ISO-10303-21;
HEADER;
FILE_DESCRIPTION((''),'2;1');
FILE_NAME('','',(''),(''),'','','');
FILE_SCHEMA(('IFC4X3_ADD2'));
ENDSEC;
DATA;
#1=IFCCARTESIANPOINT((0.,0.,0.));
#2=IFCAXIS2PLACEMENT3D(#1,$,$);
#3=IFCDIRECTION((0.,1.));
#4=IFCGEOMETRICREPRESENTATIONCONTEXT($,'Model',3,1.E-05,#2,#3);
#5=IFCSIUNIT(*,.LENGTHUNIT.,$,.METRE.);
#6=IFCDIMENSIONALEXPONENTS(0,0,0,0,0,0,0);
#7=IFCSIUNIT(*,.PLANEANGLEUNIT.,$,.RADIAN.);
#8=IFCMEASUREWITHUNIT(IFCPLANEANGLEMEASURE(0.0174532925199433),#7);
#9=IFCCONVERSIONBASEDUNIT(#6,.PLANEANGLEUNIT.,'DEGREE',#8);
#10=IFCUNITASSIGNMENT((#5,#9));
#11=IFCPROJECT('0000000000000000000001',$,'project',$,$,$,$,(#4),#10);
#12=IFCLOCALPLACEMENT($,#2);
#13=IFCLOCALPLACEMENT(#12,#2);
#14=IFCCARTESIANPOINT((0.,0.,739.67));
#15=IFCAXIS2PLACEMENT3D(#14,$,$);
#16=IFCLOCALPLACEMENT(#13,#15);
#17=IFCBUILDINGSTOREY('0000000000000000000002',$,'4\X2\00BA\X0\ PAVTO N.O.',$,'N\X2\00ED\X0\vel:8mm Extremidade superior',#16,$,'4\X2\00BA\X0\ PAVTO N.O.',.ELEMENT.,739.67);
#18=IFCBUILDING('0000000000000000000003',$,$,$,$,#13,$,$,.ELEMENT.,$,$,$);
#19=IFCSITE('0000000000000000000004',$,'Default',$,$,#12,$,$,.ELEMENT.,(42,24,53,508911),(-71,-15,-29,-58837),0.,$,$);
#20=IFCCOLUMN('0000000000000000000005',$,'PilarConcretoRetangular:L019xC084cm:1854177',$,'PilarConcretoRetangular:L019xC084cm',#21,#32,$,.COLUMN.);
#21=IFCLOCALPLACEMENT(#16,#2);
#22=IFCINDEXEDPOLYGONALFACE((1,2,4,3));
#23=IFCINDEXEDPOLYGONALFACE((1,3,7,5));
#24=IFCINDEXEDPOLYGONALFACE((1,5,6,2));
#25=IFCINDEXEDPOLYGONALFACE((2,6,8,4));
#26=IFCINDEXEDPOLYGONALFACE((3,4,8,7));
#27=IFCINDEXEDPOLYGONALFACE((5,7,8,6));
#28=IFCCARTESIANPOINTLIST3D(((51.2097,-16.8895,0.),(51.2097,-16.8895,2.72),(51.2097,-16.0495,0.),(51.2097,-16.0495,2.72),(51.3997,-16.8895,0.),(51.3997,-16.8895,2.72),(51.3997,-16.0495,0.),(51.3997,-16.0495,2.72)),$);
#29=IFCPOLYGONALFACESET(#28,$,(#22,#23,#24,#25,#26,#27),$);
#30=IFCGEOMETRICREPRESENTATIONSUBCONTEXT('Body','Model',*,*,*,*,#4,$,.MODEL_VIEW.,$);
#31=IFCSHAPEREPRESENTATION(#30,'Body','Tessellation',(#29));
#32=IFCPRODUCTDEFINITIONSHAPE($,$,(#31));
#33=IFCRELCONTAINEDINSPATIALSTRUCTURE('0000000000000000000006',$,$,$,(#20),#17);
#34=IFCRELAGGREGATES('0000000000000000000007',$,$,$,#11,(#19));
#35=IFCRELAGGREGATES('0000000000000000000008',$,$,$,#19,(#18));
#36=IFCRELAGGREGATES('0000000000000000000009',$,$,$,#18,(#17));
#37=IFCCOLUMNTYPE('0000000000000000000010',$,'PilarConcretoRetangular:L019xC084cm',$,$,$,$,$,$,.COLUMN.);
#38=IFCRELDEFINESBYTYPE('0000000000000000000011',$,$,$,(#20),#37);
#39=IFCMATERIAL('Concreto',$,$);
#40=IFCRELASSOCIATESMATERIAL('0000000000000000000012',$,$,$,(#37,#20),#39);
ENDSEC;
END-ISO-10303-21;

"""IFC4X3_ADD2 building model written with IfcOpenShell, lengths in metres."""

from ifc_helpers import new_model, entity, si_unit, converted_unit, direction, frame, frame_2d, origin, place, context, subcontext, project, spatial, rectangle, extrude, source, transform, mapped, material, material_profile, profile_set, profile_usage, type_object, type_shapes, element, save


model = new_model("IFC4X3_ADD2")

# Units and contexts
model_context = context("Model", 3, precision=1e-05, world=origin(), true_north=direction((0.0, 1.0)))
body_context = subcontext(model_context, "Body", "Model", "MODEL_VIEW")
ifc_project = project(units=[si_unit("LENGTHUNIT", "METRE"), converted_unit("PLANEANGLEUNIT", "DEGREE", entity("IfcPlaneAngleMeasure", 0.0174532925199433), si_unit("PLANEANGLEUNIT", "RADIAN"), dimensions=[0, 0, 0, 0, 0, 0, 0])], contexts=[model_context])

# Site, building, storey
site_placement = place(None, origin())
site = spatial("IfcSite", under=ifc_project, at=site_placement, Name="Default", CompositionType="ELEMENT", RefLatitude=(42, 24, 53, 508911), RefLongitude=(-71, -15, -29, -58837), RefElevation=0.0)
building_placement = place(site_placement, origin())
building = spatial("IfcBuilding", under=site, at=building_placement, CompositionType="ELEMENT")
storey_placement = place(building_placement, frame((0.0, 0.0, 739.67)))
storey = spatial("IfcBuildingStorey", under=building, at=storey_placement, Name="4º PAVTO N.O.", ObjectType="Nível:8mm Extremidade superior", LongName="4º PAVTO N.O.", CompositionType="ELEMENT", Elevation=739.67)

# Column
ifc_material = material(Name="Concreto")
ifc_material_profile_1 = material_profile(ifc_material, rectangle(XDim=0.19, YDim=0.84, at=frame_2d((0.0, 0.0), x_axis=(1.0, 0.0))), Name="L019xC084cm")
ifc_profile_set_1 = profile_set([ifc_material_profile_1], Name="L019xC084cm")
ifc_profile_usage_1 = profile_usage(ifc_profile_set_1)
column_type_1 = type_object("IfcColumnType", Name="PilarConcretoRetangular:L019xC084cm", PredefinedType="COLUMN", material=ifc_profile_set_1)
shared_shape_1 = source(origin(), body_context, "Body", "SweptSolid", [
    extrude(rectangle(XDim=0.19, YDim=0.84, at=frame_2d((0.0, 0.0), x_axis=(1.0, 0.0))), frame((51.3047, -16.4695, 739.67), z_axis=(0.0, 0.0, 1.0), x_axis=(-1.0, 0.0, 0.0)), (0.0, 0.0, 1.0), 2.72),
])
type_shapes(column_type_1, [shared_shape_1])
column_1_placement = place(storey_placement, frame((0.0, 0.0, -739.67)))
element("IfcColumn", 1, at=column_1_placement, inside=storey, type_object=column_type_1, material=ifc_profile_usage_1, Name="PilarConcretoRetangular:L019xC084cm:1854177", ObjectType="PilarConcretoRetangular:L019xC084cm", PredefinedType="COLUMN", context=body_context, shape_type="MappedRepresentation", body=[
    mapped(shared_shape_1, transform((0.0, 0.0, 0.0), scale=1.0)),
])

save(model, "model.ifc")
